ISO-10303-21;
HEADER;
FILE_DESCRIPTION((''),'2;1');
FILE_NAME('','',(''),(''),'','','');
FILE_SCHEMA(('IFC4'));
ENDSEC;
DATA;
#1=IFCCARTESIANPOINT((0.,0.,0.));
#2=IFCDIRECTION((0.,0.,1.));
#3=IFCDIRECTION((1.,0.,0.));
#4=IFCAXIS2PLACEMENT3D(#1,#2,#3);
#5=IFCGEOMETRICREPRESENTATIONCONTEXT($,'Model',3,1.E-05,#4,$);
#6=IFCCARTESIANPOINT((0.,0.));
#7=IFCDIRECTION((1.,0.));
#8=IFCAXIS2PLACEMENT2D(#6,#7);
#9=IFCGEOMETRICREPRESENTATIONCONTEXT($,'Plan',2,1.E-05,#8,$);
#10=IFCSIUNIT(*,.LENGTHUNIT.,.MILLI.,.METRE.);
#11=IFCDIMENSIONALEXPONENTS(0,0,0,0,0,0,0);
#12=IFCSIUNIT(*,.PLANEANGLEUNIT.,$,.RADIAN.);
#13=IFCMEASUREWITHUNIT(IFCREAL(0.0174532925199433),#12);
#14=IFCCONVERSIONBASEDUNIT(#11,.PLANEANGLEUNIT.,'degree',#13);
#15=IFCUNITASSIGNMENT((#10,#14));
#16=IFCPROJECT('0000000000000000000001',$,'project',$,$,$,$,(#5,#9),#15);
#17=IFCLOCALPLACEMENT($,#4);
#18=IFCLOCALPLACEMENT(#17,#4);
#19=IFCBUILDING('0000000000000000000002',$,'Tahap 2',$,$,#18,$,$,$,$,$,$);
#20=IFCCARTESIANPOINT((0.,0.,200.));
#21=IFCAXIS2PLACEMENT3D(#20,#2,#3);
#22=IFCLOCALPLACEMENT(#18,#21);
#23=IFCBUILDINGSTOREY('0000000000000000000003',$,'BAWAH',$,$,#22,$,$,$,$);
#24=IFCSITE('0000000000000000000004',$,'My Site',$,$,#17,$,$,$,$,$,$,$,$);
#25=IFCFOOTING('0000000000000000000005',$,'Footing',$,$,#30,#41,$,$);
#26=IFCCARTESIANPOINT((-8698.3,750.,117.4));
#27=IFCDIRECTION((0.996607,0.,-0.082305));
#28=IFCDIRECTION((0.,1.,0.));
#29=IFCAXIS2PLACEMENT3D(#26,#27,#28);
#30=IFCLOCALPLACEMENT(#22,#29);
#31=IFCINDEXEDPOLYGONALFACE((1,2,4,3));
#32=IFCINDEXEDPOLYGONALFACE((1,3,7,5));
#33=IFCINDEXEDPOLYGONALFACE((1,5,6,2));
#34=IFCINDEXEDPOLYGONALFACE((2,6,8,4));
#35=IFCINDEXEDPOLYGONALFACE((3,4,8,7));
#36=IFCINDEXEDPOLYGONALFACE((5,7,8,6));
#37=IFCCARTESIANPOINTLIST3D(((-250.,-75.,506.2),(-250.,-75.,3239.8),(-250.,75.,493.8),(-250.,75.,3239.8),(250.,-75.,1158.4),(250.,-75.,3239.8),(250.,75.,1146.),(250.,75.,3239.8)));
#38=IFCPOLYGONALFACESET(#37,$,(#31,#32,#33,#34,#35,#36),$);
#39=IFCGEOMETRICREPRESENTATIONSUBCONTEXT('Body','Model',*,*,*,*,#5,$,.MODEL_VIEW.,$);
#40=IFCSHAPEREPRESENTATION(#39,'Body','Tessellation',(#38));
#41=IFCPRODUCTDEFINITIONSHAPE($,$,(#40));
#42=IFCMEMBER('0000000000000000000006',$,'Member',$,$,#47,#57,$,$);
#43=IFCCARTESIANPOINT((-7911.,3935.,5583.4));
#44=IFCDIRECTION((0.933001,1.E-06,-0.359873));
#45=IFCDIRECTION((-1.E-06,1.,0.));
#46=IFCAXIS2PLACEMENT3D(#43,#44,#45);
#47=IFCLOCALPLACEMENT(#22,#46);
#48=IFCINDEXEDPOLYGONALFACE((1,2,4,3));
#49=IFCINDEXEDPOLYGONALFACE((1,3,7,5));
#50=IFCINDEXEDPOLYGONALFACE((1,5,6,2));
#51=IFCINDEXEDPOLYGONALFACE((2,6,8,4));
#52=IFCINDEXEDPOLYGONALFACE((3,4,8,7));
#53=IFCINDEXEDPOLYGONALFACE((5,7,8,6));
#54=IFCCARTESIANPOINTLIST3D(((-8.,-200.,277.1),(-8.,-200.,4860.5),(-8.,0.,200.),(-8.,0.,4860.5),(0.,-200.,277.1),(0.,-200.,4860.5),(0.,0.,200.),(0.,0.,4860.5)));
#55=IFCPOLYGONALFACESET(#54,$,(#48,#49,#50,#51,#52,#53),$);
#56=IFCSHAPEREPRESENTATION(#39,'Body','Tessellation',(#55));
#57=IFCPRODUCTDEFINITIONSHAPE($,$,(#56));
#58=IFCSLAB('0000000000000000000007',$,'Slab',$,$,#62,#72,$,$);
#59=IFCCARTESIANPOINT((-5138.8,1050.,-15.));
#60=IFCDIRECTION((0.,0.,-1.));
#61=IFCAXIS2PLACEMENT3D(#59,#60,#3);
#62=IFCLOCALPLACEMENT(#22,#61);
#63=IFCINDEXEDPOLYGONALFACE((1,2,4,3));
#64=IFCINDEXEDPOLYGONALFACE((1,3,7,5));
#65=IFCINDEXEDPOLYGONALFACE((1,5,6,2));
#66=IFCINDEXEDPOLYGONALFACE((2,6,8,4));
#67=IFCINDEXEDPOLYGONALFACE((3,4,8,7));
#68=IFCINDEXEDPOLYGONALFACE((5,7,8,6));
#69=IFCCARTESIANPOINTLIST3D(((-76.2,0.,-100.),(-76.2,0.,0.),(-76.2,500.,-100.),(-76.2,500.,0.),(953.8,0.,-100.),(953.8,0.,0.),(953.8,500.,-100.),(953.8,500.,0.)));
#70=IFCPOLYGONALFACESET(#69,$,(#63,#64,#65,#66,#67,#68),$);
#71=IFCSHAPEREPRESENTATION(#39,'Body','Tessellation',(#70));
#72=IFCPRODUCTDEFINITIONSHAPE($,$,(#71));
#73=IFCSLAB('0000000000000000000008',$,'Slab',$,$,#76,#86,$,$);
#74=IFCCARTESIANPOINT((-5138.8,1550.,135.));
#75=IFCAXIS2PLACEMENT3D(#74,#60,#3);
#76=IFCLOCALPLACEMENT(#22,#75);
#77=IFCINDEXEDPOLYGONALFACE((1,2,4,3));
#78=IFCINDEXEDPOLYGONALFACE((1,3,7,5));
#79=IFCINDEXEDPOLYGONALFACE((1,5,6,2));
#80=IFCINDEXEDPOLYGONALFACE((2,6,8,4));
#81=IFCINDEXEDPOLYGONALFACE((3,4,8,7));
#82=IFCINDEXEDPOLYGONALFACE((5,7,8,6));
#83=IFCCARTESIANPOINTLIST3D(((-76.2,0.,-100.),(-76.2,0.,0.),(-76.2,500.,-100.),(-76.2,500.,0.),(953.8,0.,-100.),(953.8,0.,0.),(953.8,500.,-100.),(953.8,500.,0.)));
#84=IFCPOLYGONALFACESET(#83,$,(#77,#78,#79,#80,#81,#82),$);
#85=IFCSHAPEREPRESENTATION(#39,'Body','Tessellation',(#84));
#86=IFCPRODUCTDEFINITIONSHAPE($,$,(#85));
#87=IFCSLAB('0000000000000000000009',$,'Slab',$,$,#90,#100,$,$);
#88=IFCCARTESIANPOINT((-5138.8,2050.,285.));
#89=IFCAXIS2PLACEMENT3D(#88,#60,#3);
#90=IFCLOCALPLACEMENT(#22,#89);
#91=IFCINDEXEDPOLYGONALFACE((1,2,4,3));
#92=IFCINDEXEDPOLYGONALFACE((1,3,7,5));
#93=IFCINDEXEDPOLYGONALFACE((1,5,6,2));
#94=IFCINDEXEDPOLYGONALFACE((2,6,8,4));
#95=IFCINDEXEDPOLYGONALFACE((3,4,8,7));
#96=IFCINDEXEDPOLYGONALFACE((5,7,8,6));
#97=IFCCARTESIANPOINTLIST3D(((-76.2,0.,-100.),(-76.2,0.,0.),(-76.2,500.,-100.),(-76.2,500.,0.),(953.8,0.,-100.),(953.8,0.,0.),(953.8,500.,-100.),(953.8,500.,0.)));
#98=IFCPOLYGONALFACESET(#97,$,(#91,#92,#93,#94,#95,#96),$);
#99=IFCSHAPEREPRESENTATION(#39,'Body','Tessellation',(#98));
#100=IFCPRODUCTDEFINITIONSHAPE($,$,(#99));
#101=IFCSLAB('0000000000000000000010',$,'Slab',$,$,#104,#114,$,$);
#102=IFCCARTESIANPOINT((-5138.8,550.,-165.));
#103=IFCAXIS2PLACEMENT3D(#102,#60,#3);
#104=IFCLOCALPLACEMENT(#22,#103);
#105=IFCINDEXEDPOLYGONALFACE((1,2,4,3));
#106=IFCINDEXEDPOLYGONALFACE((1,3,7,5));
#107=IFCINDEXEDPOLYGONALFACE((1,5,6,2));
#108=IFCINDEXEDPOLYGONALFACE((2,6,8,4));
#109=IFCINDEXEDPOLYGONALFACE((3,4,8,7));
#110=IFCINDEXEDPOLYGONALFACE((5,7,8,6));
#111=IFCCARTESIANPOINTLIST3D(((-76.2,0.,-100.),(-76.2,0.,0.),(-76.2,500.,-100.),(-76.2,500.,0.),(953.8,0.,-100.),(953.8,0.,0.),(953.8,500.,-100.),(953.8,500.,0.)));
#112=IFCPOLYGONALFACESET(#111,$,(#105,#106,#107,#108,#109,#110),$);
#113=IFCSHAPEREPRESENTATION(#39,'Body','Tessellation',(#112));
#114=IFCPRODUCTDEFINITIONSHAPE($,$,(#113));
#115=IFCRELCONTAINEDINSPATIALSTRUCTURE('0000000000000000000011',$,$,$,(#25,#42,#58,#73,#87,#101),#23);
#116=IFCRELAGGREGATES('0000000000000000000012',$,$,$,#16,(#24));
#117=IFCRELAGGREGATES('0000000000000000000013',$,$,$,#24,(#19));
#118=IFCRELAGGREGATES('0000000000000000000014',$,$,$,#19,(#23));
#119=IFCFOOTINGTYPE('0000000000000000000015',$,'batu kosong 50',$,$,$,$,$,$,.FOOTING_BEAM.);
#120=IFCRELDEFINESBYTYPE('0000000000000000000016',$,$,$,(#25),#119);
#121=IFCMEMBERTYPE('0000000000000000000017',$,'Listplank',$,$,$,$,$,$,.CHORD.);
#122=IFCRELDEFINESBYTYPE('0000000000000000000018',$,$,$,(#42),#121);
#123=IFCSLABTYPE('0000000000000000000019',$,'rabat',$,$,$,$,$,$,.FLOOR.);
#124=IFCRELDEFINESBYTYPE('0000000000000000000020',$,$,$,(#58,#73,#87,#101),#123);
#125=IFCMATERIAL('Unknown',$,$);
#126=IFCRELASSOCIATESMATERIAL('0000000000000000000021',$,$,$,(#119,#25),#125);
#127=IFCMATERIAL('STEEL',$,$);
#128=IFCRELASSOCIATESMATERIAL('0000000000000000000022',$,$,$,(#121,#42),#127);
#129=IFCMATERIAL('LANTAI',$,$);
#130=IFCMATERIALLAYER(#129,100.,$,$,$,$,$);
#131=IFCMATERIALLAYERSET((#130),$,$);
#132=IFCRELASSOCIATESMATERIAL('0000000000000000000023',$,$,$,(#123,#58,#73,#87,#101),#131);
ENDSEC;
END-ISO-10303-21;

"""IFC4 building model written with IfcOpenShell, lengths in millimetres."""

from ifc_helpers import new_model, entity, si_unit, converted_unit, frame, origin_with_axes, origin_2d_with_axis, place, context, subcontext, project, spatial, indexed_curve, rectangle, outline, extrude, clip, halfspace, material, layer, layer_set, layer_usage, material_profile, profile_set, profile_usage, type_object, element, save


model = new_model("IFC4")

# Units and contexts
model_context = context("Model", 3, precision=1e-05, world=origin_with_axes())
plan_context = context("Plan", 2, precision=1e-05, world=origin_2d_with_axis())
body_context = subcontext(model_context, "Body", "Model", "MODEL_VIEW")
ifc_project = project(units=[si_unit("LENGTHUNIT", "METRE", prefix="MILLI"), converted_unit("PLANEANGLEUNIT", "degree", entity("IfcReal", 0.0174532925199433), si_unit("PLANEANGLEUNIT", "RADIAN"), dimensions=[0, 0, 0, 0, 0, 0, 0])], contexts=[model_context, plan_context])

# Site, building, storey
site_placement = place(None, origin_with_axes())
site = spatial("IfcSite", under=ifc_project, at=site_placement, Name="My Site")
building_placement = place(site_placement, origin_with_axes())
building = spatial("IfcBuilding", under=site, at=building_placement, Name="Tahap 2")
storey_placement = place(building_placement, frame((0.0, 0.0, 200.0), z_axis=(0.0, 0.0, 1.0), x_axis=(1.0, 0.0, 0.0)))
storey = spatial("IfcBuildingStorey", under=building, at=storey_placement, Name="BAWAH")

# Footing
ifc_material_1 = material(Name="Unknown")
ifc_material_profile_1 = material_profile(ifc_material_1, rectangle(XDim=500.0, YDim=150.0, kind="CURVE"))
ifc_profile_set_1 = profile_set([ifc_material_profile_1])
ifc_profile_usage_1 = profile_usage(ifc_profile_set_1)
footing_type_1 = type_object("IfcFootingType", Name="batu kosong 50", PredefinedType="FOOTING_BEAM", material=ifc_profile_set_1)
footing_1_placement = place(storey_placement, frame((-8698.3, 750.0, 117.4), z_axis=(0.996607, 0.0, -0.082305), x_axis=(0.0, 1.0, 0.0)))
element("IfcFooting", 1, at=footing_1_placement, inside=storey, type_object=footing_type_1, material=ifc_profile_usage_1, Name="Footing", context=body_context, shape_type="Clipping", body=[
    clip(extrude(rectangle(XDim=500.0, YDim=150.0, kind="CURVE"), origin_with_axes(), (0.0, 0.0, 1.0), 3239.8), halfspace(frame((-250.0, -275.3, 522.7), z_axis=(0.792624, -0.050182, -0.607643), x_axis=(-0.063185, -0.998002, 0.0)), False)),
])

# Shared definitions
ifc_material_2 = material(Name="STEEL")

# Member
ifc_material_profile_2 = material_profile(ifc_material_2, rectangle(XDim=8.0, YDim=200.0, kind="CURVE"))
ifc_profile_set_2 = profile_set([ifc_material_profile_2])
ifc_profile_usage_2 = profile_usage(ifc_profile_set_2, cardinal=7)
member_type_1 = type_object("IfcMemberType", Name="Listplank", PredefinedType="CHORD", material=ifc_profile_set_2)
member_1_placement = place(storey_placement, frame((-7911.0, 3935.0, 5583.4), z_axis=(0.933001, 0.000001, -0.359873), x_axis=(-0.000001, 1.0, 0.0)))
element("IfcMember", 2, at=member_1_placement, inside=storey, type_object=member_type_1, material=ifc_profile_usage_2, Name="Member", context=body_context, shape_type="Clipping", body=[
    clip(extrude(rectangle(XDim=8.0, YDim=200.0, kind="CURVE"), frame((-4.0, -100.0, 0.0), z_axis=(0.0, 0.0, 1.0), x_axis=(1.0, 0.0, 0.0)), (0.0, 0.0, 1.0), 4860.5), halfspace(frame((13922.0, 2.5, 199.1), z_axis=(0.000001, -0.359873, -0.933001), x_axis=(-1.0, -0.000001, 0.0)), False)),
])

# Slabs
ifc_material_3 = material(Name="LANTAI")
ifc_layer = layer(ifc_material_3, 100.0)
ifc_layer_set = layer_set([ifc_layer])
ifc_layer_usage_1 = layer_usage(ifc_layer_set, "AXIS3", "NEGATIVE", 0.0)
slab_type = type_object("IfcSlabType", Name="rabat", PredefinedType="FLOOR", material=ifc_layer_set)
slab_1_placement = place(storey_placement, frame((-5138.8, 1050.0, -15.0), z_axis=(0.0, 0.0, -1.0), x_axis=(1.0, 0.0, 0.0)))
element("IfcSlab", 3, at=slab_1_placement, inside=storey, type_object=slab_type, material=ifc_layer_usage_1, Name="Slab", context=body_context, shape_type="SweptSolid", body=[
    extrude(outline(indexed_curve([(-76.2, 0.0), (953.8, 0.0), (953.8, 500.0), (-76.2, 500.0), (-76.2, 0.0)])), None, (0.0, 0.0, -1.0), 100.0),
])
ifc_layer_usage_2 = layer_usage(ifc_layer_set, "AXIS3", "NEGATIVE", 0.0)
slab_2_placement = place(storey_placement, frame((-5138.8, 1550.0, 135.0), z_axis=(0.0, 0.0, -1.0), x_axis=(1.0, 0.0, 0.0)))
element("IfcSlab", 4, at=slab_2_placement, inside=storey, type_object=slab_type, material=ifc_layer_usage_2, Name="Slab", context=body_context, shape_type="SweptSolid", body=[
    extrude(outline(indexed_curve([(-76.2, 500.0), (953.8, 500.0), (953.8, 0.0), (-76.2, 0.0), (-76.2, 500.0)])), None, (0.0, 0.0, -1.0), 100.0),
])
ifc_layer_usage_3 = layer_usage(ifc_layer_set, "AXIS3", "NEGATIVE", 0.0)
slab_3_placement = place(storey_placement, frame((-5138.8, 2050.0, 285.0), z_axis=(0.0, 0.0, -1.0), x_axis=(1.0, 0.0, 0.0)))
element("IfcSlab", 5, at=slab_3_placement, inside=storey, type_object=slab_type, material=ifc_layer_usage_3, Name="Slab", context=body_context, shape_type="SweptSolid", body=[
    extrude(outline(indexed_curve([(-76.2, 500.0), (953.8, 500.0), (953.8, 0.0), (-76.2, 0.0), (-76.2, 500.0)])), None, (0.0, 0.0, -1.0), 100.0),
])
ifc_layer_usage_4 = layer_usage(ifc_layer_set, "AXIS3", "NEGATIVE", 0.0)
slab_4_placement = place(storey_placement, frame((-5138.8, 550.0, -165.0), z_axis=(0.0, 0.0, -1.0), x_axis=(1.0, 0.0, 0.0)))
element("IfcSlab", 6, at=slab_4_placement, inside=storey, type_object=slab_type, material=ifc_layer_usage_4, Name="Slab", context=body_context, shape_type="SweptSolid", body=[
    extrude(outline(indexed_curve([(-76.2, 500.0), (953.8, 500.0), (953.8, 0.0), (-76.2, 0.0), (-76.2, 500.0)])), None, (0.0, 0.0, -1.0), 100.0),
])

save(model, "model.ifc")
